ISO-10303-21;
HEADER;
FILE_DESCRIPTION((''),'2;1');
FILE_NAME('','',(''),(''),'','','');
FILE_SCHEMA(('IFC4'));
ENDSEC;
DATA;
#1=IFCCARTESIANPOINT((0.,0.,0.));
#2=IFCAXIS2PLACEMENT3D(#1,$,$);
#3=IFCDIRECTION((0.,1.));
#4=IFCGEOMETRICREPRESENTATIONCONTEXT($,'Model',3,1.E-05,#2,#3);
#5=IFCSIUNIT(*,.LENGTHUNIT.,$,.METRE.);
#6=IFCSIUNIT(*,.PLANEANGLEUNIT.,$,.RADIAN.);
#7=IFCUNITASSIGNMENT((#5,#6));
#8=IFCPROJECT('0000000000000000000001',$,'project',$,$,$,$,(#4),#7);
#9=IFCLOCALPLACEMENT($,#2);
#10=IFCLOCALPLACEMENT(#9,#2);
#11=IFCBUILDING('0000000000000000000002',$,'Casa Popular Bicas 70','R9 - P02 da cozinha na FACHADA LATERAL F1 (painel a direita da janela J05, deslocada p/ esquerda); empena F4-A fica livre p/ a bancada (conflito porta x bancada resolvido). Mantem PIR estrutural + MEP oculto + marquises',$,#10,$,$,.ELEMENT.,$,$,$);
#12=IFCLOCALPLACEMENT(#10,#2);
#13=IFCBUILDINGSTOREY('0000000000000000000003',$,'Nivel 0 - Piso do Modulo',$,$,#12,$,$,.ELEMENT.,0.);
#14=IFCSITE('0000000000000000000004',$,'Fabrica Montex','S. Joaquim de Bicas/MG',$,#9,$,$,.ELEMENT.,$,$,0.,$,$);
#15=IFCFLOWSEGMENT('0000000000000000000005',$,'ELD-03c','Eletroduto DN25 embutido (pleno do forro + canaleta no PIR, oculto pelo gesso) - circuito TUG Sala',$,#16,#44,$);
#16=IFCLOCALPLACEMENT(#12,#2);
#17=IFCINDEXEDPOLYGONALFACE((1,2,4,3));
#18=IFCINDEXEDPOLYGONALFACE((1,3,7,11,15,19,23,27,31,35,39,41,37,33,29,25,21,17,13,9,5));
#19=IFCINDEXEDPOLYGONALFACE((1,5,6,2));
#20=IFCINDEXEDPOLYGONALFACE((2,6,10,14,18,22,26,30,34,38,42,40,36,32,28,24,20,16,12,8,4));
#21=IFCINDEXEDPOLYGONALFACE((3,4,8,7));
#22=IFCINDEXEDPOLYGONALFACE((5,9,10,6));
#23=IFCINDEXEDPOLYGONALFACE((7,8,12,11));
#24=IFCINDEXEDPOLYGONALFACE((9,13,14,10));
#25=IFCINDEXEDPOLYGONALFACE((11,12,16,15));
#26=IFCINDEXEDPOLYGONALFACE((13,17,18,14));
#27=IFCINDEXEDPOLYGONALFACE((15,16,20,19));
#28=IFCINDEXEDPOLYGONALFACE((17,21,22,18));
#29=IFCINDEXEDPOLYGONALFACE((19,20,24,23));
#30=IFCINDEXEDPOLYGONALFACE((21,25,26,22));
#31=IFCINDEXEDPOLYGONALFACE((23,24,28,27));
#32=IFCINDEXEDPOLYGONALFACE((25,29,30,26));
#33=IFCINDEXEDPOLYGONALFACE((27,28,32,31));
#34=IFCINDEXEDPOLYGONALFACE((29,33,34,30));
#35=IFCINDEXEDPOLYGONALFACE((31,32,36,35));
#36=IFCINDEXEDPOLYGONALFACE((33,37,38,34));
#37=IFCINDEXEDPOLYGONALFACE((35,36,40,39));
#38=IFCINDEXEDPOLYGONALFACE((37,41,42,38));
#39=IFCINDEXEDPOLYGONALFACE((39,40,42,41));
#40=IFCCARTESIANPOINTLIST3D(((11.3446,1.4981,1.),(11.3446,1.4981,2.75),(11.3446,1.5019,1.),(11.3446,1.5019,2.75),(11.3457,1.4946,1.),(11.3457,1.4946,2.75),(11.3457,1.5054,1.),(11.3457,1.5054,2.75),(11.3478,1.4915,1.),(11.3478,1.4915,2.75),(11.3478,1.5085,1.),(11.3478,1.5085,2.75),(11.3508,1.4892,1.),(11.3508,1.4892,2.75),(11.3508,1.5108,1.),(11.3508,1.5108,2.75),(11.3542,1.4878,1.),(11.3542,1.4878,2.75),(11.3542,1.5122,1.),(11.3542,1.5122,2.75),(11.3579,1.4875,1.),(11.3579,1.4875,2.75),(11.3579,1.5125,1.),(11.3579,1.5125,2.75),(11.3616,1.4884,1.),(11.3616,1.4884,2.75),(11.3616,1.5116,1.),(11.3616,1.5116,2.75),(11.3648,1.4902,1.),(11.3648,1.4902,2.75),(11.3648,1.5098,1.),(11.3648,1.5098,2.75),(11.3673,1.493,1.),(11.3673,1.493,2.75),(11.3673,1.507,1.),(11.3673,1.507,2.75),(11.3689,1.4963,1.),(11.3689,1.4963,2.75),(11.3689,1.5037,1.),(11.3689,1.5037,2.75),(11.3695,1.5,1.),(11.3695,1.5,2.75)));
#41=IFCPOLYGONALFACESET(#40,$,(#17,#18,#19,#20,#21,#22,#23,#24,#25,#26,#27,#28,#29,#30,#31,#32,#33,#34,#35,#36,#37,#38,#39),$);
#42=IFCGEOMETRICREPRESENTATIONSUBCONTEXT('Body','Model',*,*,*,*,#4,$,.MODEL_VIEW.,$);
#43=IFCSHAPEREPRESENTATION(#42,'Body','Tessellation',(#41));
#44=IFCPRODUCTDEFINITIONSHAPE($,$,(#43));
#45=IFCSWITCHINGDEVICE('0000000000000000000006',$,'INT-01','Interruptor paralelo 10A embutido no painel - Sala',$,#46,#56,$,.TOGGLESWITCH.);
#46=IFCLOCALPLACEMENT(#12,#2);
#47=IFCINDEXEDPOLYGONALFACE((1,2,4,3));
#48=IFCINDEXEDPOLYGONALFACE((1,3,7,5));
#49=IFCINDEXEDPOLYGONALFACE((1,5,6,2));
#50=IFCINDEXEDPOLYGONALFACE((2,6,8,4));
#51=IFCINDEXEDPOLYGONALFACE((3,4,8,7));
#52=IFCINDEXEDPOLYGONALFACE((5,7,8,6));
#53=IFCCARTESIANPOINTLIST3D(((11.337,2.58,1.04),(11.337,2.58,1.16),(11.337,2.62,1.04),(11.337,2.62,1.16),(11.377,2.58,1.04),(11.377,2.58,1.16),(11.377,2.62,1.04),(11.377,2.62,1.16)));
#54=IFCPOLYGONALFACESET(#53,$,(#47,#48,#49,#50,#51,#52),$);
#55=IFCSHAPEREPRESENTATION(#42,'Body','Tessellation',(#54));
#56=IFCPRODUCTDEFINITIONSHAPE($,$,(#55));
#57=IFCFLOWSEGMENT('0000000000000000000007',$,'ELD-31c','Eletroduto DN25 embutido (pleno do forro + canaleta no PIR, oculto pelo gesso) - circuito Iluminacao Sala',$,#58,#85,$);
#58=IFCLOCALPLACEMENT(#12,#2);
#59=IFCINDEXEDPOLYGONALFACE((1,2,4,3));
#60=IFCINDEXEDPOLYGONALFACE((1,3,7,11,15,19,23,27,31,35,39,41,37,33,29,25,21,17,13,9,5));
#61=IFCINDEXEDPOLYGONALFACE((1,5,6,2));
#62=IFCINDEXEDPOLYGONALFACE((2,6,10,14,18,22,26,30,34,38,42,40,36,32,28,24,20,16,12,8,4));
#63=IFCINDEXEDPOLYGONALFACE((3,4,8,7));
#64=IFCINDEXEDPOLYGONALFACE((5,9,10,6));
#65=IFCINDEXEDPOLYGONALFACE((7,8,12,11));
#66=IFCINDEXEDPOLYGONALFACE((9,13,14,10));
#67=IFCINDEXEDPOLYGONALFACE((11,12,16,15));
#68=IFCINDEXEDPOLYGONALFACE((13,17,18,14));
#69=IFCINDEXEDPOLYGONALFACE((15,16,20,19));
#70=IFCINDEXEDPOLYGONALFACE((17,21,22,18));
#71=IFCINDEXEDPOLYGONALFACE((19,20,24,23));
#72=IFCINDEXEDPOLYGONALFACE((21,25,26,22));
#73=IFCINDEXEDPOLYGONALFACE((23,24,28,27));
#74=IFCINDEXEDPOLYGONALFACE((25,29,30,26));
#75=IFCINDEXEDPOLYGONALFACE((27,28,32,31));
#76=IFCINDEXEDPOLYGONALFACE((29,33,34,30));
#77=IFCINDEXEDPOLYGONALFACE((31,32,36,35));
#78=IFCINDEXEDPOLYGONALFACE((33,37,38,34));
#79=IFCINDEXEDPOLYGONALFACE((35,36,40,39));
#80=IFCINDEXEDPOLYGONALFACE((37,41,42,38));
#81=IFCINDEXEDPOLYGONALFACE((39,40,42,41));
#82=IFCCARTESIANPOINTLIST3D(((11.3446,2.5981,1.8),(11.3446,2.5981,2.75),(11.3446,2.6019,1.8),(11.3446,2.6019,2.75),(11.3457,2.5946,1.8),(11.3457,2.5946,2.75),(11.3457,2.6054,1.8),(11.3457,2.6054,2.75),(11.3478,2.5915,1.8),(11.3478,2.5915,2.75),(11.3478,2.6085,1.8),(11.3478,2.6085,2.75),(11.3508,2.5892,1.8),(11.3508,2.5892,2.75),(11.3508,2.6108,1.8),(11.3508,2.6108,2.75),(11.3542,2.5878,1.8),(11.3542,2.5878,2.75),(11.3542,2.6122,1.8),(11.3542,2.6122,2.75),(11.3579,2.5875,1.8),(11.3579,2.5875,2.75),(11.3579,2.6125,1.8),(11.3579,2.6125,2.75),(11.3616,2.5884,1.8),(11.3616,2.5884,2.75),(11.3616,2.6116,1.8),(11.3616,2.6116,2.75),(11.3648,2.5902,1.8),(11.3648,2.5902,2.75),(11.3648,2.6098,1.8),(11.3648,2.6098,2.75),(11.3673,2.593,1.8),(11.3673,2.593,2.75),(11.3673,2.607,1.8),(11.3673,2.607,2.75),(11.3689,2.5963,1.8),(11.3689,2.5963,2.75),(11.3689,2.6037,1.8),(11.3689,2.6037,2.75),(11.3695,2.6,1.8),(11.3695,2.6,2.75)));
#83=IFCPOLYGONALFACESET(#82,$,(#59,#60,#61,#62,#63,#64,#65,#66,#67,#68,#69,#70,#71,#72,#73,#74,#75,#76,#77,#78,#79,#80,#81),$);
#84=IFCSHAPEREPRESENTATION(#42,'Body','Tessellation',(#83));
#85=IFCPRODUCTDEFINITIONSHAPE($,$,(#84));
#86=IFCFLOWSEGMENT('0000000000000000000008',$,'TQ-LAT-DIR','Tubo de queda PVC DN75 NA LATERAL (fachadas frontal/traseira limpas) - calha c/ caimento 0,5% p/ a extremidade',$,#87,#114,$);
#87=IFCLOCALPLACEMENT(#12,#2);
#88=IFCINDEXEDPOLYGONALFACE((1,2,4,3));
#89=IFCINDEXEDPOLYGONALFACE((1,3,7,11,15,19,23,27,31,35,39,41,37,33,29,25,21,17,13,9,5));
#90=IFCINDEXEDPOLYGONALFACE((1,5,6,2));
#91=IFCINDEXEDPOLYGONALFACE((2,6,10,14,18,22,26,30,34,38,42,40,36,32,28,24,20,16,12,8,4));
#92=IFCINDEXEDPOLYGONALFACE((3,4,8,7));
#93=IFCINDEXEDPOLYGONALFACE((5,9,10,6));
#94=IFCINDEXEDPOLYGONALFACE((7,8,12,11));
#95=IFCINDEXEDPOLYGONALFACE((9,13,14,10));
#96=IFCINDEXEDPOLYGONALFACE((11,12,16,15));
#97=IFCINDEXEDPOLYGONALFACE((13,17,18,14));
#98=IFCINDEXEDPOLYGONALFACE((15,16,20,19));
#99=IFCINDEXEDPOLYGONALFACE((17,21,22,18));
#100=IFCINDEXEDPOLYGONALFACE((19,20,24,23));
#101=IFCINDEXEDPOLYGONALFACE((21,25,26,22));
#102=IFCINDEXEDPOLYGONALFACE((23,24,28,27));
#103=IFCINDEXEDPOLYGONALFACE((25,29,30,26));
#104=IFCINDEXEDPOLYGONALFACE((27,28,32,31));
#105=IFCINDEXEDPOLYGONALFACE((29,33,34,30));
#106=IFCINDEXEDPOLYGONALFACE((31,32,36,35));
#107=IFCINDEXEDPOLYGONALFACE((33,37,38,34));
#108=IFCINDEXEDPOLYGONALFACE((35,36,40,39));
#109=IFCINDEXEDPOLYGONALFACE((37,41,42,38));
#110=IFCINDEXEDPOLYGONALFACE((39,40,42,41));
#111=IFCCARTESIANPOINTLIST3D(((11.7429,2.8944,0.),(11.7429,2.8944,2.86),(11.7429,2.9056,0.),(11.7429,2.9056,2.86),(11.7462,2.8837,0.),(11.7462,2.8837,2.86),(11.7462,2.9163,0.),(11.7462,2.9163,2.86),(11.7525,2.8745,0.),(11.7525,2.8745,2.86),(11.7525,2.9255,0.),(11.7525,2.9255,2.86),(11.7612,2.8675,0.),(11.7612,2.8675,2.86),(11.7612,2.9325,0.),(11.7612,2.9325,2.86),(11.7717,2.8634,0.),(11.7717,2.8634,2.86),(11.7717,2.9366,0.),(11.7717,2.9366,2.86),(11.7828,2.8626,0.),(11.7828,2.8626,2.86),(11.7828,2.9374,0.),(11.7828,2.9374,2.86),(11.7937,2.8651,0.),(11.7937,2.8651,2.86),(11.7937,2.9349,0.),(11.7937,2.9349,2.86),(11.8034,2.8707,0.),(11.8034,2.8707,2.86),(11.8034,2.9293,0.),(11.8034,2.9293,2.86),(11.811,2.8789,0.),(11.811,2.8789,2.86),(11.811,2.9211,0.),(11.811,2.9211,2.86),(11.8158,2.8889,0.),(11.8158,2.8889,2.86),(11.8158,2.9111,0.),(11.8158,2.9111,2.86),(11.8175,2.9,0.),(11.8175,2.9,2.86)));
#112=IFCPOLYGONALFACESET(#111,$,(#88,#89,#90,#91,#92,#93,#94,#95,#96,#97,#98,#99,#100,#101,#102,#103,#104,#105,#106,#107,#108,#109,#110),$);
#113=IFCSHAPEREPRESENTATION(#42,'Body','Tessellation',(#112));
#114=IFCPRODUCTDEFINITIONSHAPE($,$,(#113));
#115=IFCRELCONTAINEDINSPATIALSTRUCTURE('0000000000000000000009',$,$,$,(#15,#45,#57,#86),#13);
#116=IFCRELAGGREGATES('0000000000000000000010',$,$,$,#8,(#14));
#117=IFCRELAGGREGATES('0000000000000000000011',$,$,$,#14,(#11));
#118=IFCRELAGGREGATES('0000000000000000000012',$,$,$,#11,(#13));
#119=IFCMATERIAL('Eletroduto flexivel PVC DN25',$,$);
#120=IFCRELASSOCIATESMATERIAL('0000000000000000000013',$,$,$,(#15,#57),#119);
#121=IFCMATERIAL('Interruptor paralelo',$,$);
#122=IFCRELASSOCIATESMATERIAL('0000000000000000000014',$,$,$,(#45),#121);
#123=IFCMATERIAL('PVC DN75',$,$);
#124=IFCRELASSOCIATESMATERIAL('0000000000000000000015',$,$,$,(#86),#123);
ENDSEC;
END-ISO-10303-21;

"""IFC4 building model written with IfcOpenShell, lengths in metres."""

from ifc_helpers import new_model, si_unit, direction, frame, frame_2d, origin, origin_2d, place, context, subcontext, project, spatial, rectangle, circle, extrude, material, element, save


model = new_model("IFC4")

# Units and contexts
model_context = context("Model", 3, precision=1e-05, world=origin(), true_north=direction((0.0, 1.0)))
body_context = subcontext(model_context, "Body", "Model", "MODEL_VIEW")
ifc_project = project(units=[si_unit("LENGTHUNIT", "METRE"), si_unit("PLANEANGLEUNIT", "RADIAN")], contexts=[model_context])

# Site, building, storey
site_placement = place(None, origin())
site = spatial("IfcSite", under=ifc_project, at=site_placement, Name="Fabrica Montex", Description="S. Joaquim de Bicas/MG", CompositionType="ELEMENT", RefElevation=0.0)
building_placement = place(site_placement, origin())
building = spatial("IfcBuilding", under=site, at=building_placement, Name="Casa Popular Bicas 70", Description="R9 - P02 da cozinha na FACHADA LATERAL F1 (painel a direita da janela J05, deslocada p/ esquerda); empena F4-A fica livre p/ a bancada (conflito porta x bancada resolvido). Mantem PIR estrutural + MEP oculto + marquises", CompositionType="ELEMENT")
storey_placement = place(building_placement, origin())
storey = spatial("IfcBuildingStorey", under=building, at=storey_placement, Name="Nivel 0 - Piso do Modulo", CompositionType="ELEMENT", Elevation=0.0)

# Flow segment
ifc_material_1 = material(Name="Eletroduto flexivel PVC DN25")
flow_segment_1_placement = place(storey_placement, frame((11.357, 1.5, 2.75), z_axis=(0.0, 0.0, -1.0), x_axis=(1.0, 0.0, 0.0)))
element("IfcFlowSegment", 1, at=flow_segment_1_placement, inside=storey, material=ifc_material_1, Name="ELD-03c", Description="Eletroduto DN25 embutido (pleno do forro + canaleta no PIR, oculto pelo gesso) - circuito TUG Sala", context=body_context, shape_type="SweptSolid", body=[
    extrude(circle(Radius=0.0125, at=origin_2d()), origin(), (0.0, 0.0, 1.0), 1.75),
])

# Switching device
ifc_material_2 = material(Name="Interruptor paralelo")
switching_device_placement = place(storey_placement, frame((11.337, 2.58, 1.04)))
element("IfcSwitchingDevice", 2, at=switching_device_placement, inside=storey, material=ifc_material_2, Name="INT-01", Description="Interruptor paralelo 10A embutido no painel - Sala", PredefinedType="TOGGLESWITCH", context=body_context, shape_type="SweptSolid", body=[
    extrude(rectangle(XDim=0.04, YDim=0.04, at=frame_2d((0.02, 0.02))), origin(), (0.0, 0.0, 1.0), 0.12),
])

# Flow segments
flow_segment_2_placement = place(storey_placement, frame((11.357, 2.6, 2.75), z_axis=(0.0, 0.0, -1.0), x_axis=(1.0, 0.0, 0.0)))
element("IfcFlowSegment", 3, at=flow_segment_2_placement, inside=storey, material=ifc_material_1, Name="ELD-31c", Description="Eletroduto DN25 embutido (pleno do forro + canaleta no PIR, oculto pelo gesso) - circuito Iluminacao Sala", context=body_context, shape_type="SweptSolid", body=[
    extrude(circle(Radius=0.0125, at=origin_2d()), origin(), (0.0, 0.0, 1.0), 0.95),
])
ifc_material_3 = material(Name="PVC DN75")
flow_segment_3_placement = place(storey_placement, frame((11.78, 2.9, 0.0)))
element("IfcFlowSegment", 4, at=flow_segment_3_placement, inside=storey, material=ifc_material_3, Name="TQ-LAT-DIR", Description="Tubo de queda PVC DN75 NA LATERAL (fachadas frontal/traseira limpas) - calha c/ caimento 0,5% p/ a extremidade", context=body_context, shape_type="SweptSolid", body=[
    extrude(circle(Radius=0.0375, at=origin_2d()), origin(), (0.0, 0.0, 1.0), 2.86),
])

save(model, "model.ifc")
